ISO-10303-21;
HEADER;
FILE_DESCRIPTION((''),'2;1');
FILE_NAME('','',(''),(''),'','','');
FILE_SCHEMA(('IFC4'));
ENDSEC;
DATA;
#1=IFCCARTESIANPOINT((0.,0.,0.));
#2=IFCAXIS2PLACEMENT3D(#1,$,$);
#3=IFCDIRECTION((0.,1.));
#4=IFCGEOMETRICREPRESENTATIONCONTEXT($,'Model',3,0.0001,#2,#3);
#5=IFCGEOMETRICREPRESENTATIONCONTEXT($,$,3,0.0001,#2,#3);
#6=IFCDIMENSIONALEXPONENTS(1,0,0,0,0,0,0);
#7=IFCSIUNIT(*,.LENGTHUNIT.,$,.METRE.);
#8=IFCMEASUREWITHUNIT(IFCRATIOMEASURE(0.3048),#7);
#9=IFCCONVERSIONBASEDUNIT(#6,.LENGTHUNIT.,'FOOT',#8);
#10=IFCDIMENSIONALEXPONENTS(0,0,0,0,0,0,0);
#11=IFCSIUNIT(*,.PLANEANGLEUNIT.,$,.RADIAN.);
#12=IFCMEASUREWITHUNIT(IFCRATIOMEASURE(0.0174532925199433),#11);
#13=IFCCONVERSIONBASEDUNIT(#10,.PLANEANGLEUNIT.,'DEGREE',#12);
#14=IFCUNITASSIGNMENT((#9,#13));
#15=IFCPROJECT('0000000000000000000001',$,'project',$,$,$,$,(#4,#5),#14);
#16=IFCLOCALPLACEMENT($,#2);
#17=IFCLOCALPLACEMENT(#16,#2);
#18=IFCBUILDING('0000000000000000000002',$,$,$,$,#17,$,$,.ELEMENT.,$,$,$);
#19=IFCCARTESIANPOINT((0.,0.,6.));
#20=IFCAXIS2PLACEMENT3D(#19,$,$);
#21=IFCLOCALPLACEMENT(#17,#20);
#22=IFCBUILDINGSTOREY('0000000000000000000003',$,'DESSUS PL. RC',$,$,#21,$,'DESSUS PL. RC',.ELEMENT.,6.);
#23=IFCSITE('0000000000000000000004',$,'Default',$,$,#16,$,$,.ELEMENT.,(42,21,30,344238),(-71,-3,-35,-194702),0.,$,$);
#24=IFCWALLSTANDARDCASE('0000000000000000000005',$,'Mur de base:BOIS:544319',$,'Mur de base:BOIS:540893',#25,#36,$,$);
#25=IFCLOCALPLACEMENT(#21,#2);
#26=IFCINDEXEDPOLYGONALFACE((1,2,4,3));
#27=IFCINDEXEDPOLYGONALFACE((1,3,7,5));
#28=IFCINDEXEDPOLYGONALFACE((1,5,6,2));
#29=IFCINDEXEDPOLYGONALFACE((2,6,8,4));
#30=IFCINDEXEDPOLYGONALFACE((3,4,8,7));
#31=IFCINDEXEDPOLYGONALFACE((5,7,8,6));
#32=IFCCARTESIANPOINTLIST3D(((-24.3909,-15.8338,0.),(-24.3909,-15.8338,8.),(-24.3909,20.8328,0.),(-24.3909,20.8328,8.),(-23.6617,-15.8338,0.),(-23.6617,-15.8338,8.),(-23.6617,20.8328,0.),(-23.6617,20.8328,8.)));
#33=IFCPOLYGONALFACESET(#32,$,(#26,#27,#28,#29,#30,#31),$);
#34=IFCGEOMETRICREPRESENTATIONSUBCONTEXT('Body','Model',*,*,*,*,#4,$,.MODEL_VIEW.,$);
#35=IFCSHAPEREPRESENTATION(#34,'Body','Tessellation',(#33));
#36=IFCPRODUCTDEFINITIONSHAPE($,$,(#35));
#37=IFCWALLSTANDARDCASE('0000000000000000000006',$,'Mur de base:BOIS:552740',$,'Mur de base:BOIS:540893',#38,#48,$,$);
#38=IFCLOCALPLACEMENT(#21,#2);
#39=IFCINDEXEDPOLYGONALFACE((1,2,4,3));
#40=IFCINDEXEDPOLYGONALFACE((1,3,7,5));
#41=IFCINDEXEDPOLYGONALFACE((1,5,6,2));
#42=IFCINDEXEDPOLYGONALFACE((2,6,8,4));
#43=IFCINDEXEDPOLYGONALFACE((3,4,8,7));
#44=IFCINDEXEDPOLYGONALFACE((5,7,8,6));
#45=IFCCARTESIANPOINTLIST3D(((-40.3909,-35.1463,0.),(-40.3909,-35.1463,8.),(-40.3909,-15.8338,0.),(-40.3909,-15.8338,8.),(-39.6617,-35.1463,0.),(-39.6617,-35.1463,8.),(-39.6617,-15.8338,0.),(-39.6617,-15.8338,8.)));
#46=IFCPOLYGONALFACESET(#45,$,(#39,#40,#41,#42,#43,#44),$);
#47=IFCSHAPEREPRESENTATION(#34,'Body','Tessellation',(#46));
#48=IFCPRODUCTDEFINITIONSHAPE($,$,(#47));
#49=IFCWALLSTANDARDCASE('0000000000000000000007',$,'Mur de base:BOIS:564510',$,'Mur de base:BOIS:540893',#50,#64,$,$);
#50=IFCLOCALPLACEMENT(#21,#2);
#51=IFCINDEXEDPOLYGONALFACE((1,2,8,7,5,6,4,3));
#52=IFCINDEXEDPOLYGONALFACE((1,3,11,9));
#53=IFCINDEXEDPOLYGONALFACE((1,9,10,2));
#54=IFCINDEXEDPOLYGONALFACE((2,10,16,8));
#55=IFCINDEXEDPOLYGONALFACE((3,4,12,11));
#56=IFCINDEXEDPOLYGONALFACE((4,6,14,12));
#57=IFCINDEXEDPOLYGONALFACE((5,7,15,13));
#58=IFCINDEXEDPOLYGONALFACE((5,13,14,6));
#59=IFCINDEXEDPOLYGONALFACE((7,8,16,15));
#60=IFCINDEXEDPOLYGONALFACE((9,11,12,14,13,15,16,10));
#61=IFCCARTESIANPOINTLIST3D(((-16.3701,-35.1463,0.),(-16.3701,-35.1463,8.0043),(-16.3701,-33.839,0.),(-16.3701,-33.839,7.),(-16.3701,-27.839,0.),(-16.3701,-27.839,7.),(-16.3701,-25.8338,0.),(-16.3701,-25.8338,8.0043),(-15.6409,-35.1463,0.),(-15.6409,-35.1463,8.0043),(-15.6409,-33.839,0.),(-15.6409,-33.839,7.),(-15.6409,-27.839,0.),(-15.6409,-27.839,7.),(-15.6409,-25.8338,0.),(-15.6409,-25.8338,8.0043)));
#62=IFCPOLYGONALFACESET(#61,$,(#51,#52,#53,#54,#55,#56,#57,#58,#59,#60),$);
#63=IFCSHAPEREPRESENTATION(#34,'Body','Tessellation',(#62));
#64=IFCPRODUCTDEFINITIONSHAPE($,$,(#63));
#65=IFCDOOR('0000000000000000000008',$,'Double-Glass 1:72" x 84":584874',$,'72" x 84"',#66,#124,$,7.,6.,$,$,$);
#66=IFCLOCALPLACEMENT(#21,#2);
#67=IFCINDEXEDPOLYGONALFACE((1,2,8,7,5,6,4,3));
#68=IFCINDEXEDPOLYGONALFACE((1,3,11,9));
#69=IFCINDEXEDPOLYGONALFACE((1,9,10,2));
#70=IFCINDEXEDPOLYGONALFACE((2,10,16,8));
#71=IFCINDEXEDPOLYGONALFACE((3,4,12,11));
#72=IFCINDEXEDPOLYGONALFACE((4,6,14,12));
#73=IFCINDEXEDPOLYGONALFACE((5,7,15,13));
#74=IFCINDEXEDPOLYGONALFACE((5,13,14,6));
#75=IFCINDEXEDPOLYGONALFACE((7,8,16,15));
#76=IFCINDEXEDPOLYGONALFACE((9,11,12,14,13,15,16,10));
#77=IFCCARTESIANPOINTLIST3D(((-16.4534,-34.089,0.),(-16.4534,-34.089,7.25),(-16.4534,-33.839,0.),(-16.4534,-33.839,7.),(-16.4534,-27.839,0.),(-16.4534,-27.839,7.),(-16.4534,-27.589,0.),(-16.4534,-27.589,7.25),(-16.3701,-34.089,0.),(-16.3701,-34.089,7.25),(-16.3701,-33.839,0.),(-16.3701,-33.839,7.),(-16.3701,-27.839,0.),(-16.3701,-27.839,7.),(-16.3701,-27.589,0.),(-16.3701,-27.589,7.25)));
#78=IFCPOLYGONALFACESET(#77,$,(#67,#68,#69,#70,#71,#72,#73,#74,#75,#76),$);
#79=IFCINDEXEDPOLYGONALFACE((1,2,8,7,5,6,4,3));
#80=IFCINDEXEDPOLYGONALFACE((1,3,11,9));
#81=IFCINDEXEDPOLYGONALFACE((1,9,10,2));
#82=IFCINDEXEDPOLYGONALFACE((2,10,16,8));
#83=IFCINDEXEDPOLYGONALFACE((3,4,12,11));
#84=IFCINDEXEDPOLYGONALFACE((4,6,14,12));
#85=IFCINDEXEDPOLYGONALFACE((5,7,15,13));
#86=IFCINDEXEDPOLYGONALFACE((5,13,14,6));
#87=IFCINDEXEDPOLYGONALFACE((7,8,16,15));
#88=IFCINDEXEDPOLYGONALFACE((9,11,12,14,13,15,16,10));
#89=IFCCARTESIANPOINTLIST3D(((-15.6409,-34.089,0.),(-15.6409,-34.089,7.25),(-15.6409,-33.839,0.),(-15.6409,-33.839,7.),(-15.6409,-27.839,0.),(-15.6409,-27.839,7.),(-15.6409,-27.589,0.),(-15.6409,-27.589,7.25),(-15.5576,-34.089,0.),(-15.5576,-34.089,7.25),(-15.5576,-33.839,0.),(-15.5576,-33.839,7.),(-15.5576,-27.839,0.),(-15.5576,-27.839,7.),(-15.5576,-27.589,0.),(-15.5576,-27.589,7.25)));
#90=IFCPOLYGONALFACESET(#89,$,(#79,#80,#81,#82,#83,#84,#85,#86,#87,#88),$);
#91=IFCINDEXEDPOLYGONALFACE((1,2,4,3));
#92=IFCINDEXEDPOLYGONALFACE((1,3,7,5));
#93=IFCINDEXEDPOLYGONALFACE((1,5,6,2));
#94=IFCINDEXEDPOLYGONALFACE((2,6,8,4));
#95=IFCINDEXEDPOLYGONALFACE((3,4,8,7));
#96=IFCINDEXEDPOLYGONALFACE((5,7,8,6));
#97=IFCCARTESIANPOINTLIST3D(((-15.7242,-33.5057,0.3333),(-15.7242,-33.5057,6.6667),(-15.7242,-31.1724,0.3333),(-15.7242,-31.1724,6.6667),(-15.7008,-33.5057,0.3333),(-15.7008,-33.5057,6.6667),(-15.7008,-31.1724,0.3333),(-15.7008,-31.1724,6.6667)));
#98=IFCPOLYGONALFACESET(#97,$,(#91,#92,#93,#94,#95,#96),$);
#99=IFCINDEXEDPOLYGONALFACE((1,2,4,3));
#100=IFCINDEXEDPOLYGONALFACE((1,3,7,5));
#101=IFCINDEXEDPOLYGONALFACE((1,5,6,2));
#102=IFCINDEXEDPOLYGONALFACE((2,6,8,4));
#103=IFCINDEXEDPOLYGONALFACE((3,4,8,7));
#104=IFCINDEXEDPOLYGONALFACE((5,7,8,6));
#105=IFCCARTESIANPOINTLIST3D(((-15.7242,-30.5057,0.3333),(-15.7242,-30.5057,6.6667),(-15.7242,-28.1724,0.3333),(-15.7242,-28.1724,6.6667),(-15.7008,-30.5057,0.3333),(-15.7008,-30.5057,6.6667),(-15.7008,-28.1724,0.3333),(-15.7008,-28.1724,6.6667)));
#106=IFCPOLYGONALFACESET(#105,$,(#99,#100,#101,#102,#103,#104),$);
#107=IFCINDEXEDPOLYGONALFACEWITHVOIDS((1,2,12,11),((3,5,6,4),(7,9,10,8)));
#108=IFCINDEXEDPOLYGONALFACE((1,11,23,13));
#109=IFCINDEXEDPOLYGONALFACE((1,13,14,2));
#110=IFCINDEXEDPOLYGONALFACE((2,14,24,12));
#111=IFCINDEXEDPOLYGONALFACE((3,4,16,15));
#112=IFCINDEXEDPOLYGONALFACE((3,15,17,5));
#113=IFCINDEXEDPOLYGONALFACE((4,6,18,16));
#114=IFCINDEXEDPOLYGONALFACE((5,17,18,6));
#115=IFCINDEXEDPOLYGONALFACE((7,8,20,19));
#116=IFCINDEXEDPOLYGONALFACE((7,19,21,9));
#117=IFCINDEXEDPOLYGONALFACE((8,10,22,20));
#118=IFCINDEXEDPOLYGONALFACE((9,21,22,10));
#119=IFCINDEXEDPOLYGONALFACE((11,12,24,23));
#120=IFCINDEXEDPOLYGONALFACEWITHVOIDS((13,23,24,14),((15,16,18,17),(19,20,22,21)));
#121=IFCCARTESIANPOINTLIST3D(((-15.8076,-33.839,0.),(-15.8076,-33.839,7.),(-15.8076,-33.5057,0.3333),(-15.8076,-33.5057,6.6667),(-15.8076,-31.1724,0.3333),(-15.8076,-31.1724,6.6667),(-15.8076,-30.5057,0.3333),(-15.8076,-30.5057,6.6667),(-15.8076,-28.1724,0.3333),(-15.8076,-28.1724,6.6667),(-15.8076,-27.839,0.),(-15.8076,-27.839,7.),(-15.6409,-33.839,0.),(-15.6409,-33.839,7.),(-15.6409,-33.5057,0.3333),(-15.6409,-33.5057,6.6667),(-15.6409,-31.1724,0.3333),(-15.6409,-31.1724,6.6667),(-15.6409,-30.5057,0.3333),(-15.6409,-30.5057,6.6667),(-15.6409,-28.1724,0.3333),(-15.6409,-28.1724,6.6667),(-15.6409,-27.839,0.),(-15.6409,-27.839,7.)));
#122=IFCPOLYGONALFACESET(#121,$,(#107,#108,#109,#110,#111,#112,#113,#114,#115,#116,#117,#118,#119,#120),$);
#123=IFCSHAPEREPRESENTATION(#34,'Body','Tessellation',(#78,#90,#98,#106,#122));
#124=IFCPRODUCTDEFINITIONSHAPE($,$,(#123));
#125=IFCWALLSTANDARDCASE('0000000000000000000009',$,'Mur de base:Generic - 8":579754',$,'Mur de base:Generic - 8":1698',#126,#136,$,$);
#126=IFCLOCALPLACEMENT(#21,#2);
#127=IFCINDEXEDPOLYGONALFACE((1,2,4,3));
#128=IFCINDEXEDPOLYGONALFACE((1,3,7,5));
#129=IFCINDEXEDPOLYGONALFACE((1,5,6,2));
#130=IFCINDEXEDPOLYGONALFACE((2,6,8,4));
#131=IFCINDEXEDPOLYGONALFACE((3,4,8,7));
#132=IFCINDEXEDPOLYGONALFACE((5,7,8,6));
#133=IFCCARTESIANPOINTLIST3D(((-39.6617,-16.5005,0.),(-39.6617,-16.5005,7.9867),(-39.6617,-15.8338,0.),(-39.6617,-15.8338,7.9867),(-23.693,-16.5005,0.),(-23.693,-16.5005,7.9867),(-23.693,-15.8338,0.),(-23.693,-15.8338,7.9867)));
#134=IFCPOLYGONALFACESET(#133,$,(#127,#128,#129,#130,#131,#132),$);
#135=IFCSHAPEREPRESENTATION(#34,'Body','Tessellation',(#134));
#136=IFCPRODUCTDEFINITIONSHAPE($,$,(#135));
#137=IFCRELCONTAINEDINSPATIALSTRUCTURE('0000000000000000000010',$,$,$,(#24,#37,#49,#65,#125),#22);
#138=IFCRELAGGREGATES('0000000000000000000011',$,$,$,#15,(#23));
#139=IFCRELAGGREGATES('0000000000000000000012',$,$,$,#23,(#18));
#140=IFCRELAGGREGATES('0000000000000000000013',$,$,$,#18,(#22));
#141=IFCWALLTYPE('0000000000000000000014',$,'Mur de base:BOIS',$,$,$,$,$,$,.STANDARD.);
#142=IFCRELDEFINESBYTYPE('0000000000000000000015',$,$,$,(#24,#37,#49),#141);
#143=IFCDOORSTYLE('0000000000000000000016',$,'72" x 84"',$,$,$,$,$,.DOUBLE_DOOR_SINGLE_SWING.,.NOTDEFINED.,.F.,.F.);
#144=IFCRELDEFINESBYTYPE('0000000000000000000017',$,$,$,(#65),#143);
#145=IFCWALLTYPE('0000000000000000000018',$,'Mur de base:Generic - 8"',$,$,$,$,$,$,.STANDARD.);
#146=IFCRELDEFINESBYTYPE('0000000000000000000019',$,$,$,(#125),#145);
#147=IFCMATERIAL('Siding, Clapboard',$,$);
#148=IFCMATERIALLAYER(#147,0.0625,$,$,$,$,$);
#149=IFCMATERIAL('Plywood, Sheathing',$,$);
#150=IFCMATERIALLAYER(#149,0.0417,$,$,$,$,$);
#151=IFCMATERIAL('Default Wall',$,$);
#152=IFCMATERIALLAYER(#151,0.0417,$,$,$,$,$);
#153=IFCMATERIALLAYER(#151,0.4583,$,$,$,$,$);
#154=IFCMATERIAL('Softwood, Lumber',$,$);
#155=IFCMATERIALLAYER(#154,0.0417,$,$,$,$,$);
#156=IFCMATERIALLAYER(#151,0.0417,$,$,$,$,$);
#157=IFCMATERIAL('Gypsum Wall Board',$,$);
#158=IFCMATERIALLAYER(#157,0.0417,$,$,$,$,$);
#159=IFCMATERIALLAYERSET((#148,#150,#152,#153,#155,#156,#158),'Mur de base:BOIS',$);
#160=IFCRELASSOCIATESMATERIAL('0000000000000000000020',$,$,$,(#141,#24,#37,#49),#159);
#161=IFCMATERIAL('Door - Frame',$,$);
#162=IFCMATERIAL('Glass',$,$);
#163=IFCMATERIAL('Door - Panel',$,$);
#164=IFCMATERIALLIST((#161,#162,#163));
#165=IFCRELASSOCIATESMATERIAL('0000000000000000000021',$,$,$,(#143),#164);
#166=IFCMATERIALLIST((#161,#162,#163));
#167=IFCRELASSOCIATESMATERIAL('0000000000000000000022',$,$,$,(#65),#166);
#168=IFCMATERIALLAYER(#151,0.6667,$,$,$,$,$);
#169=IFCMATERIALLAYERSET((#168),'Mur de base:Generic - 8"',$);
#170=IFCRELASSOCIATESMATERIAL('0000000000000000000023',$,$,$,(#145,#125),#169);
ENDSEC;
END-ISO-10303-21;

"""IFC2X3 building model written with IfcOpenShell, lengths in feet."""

from ifc_helpers import new_model, entity, si_unit, converted_unit, direction, frame, frame_2d, origin, origin_2d_with_axis, place, context, subcontext, project, spatial, polyline, rectangle, outline, extrude, source, transform, mapped, material, material_list, layer, layer_set, layer_usage, type_object, type_shapes, element, fill, save


model = new_model("IFC2X3")

# Units and contexts
model_context = context("Model", 3, precision=0.0001, world=origin(), true_north=direction((0.0, 1.0)))
context_of_model = context(None, 3, precision=0.0001, world=origin(), true_north=direction((0.0, 1.0)))
body_context = subcontext(model_context, "Body", "Model", "MODEL_VIEW")
ifc_project = project(units=[converted_unit("LENGTHUNIT", "FOOT", entity("IfcRatioMeasure", 0.3048), si_unit("LENGTHUNIT", "METRE"), dimensions=[1, 0, 0, 0, 0, 0, 0]), converted_unit("PLANEANGLEUNIT", "DEGREE", entity("IfcRatioMeasure", 0.0174532925199433), si_unit("PLANEANGLEUNIT", "RADIAN"), dimensions=[0, 0, 0, 0, 0, 0, 0])], contexts=[model_context, context_of_model])

# Site, building, storey
site_placement = place(None, origin())
site = spatial("IfcSite", under=ifc_project, at=site_placement, Name="Default", CompositionType="ELEMENT", RefLatitude=(42, 21, 30, 344238), RefLongitude=(-71, -3, -35, -194702), RefElevation=0.0)
building_placement = place(site_placement, origin())
building = spatial("IfcBuilding", under=site, at=building_placement, CompositionType="ELEMENT")
storey_placement = place(building_placement, frame((0.0, 0.0, 6.0)))
storey = spatial("IfcBuildingStorey", under=building, at=storey_placement, Name="DESSUS PL. RC", LongName="DESSUS PL. RC", CompositionType="ELEMENT", Elevation=6.0)

# Wall
ifc_material_1 = material(Name="Siding, Clapboard")
ifc_layer_1 = layer(ifc_material_1, 0.0625)
ifc_material_2 = material(Name="Plywood, Sheathing")
ifc_layer_2 = layer(ifc_material_2, 0.0417)
ifc_material_3 = material(Name="Default Wall")
ifc_layer_3 = layer(ifc_material_3, 0.0417)
ifc_layer_4 = layer(ifc_material_3, 0.4583)
ifc_material_4 = material(Name="Softwood, Lumber")
ifc_layer_5 = layer(ifc_material_4, 0.0417)
ifc_layer_6 = layer(ifc_material_3, 0.0417)
ifc_material_5 = material(Name="Gypsum Wall Board")
ifc_layer_7 = layer(ifc_material_5, 0.0417)
ifc_layer_set_1 = layer_set([ifc_layer_1, ifc_layer_2, ifc_layer_3, ifc_layer_4, ifc_layer_5, ifc_layer_6, ifc_layer_7], Name="Mur de base:BOIS")
ifc_layer_usage_1 = layer_usage(ifc_layer_set_1, "AXIS2", "NEGATIVE", 0.3646)
wall_type_1 = type_object("IfcWallType", Name="Mur de base:BOIS", PredefinedType="STANDARD", material=ifc_layer_set_1)
wall_1_placement = place(storey_placement, frame((-24.0263, -15.8338, 0.0), z_axis=(0.0, 0.0, 1.0), x_axis=(0.0, 1.0, 0.0)))
element("IfcWallStandardCase", 1, at=wall_1_placement, inside=storey, type_object=wall_type_1, material=ifc_layer_usage_1, Name="Mur de base:BOIS:544319", ObjectType="Mur de base:BOIS:540893", context=body_context, shape_type="SweptSolid", body=[
    extrude(rectangle(XDim=36.6667, YDim=0.7292, at=frame_2d((18.3333, 0.0), x_axis=(-1.0, 0.0))), origin(), (0.0, 0.0, 1.0), 8.0),
])

# Shared definitions
ifc_material_6 = material(Name="Glass")

# Wall
ifc_layer_usage_2 = layer_usage(ifc_layer_set_1, "AXIS2", "NEGATIVE", 0.3646)
wall_2_placement = place(storey_placement, frame((-40.0263, -35.1463, 0.0), z_axis=(0.0, 0.0, 1.0), x_axis=(0.0, 1.0, 0.0)))
element("IfcWallStandardCase", 2, at=wall_2_placement, inside=storey, type_object=wall_type_1, material=ifc_layer_usage_2, Name="Mur de base:BOIS:552740", ObjectType="Mur de base:BOIS:540893", context=body_context, shape_type="SweptSolid", body=[
    extrude(rectangle(XDim=19.3125, YDim=0.7292, at=frame_2d((9.6562, 0.0), x_axis=(-1.0, 0.0))), origin(), (0.0, 0.0, 1.0), 8.0),
])

# Wall, opening, door
ifc_layer_usage_3 = layer_usage(ifc_layer_set_1, "AXIS2", "NEGATIVE", 0.3646)
wall_3_placement = place(storey_placement, frame((-16.0055, -35.1463, 0.0), z_axis=(0.0, 0.0, 1.0), x_axis=(0.0, 1.0, 0.0)))
wall_3 = element("IfcWallStandardCase", 3, at=wall_3_placement, inside=storey, type_object=wall_type_1, material=ifc_layer_usage_3, Name="Mur de base:BOIS:564510", ObjectType="Mur de base:BOIS:540893", context=body_context, shape_type="SweptSolid", body=[
    extrude(rectangle(XDim=9.3125, YDim=0.7292, at=frame_2d((4.6562, 0.0), x_axis=(-1.0, 0.0))), origin(), (0.0, 0.0, 1.0), 8.0043),
])
opening_1_placement = place(wall_3_placement, frame((7.3073, 0.3646, 0.0)))
opening_1 = element("IfcOpeningElement", 4, at=opening_1_placement, cuts=wall_3, ObjectType="Opening", context=body_context, shape_type="SweptSolid", body=[
    extrude(rectangle(XDim=6.0, YDim=7.0, at=frame_2d((3.5, 3.0), x_axis=(0.0, 1.0))), frame((0.0, 0.0, 0.0), z_axis=(0.0, -1.0, 0.0), x_axis=(0.0, 0.0, 1.0)), (0.0, 0.0, 1.0), 0.7292),
])
ifc_material_7 = material(Name="Door - Frame")
ifc_material_8 = material(Name="Door - Panel")
ifc_material_list_1 = material_list([ifc_material_7, ifc_material_6, ifc_material_8])
ifc_material_list_2 = material_list([ifc_material_7, ifc_material_6, ifc_material_8])
door_style_1 = type_object("IfcDoorStyle", Name="72\" x 84\"", ConstructionType="NOTDEFINED", OperationType="DOUBLE_DOOR_SINGLE_SWING", ParameterTakesPrecedence=False, Sizeable=False, material=ifc_material_list_2)
shared_shape_1 = source(origin(), body_context, "Body", "SweptSolid", [
    extrude(outline(polyline([(-3.25, -3.5625), (-3.0, -3.5625), (-3.0, 3.4375), (3.0, 3.4375), (3.0, -3.5625), (3.25, -3.5625), (3.25, 3.6875), (-3.25, 3.6875), (-3.25, -3.5625)])), frame((3.0, -0.0833, 3.5625), z_axis=(0.0, 1.0, 0.0), x_axis=(-1.0, 0.0, 0.0)), (0.0, 0.0, 1.0), 0.0833),
    extrude(outline(polyline([(-3.0, -3.4375), (-3.0, 3.5625), (-3.25, 3.5625), (-3.25, -3.6875), (3.25, -3.6875), (3.25, 3.5625), (3.0, 3.5625), (3.0, -3.4375), (-3.0, -3.4375)])), frame((3.0, 0.7292, 3.5625), z_axis=(0.0, -1.0, 0.0), x_axis=(-1.0, 0.0, 0.0)), (0.0, 0.0, -1.0), 0.0833),
    extrude(rectangle(XDim=0.0234, YDim=2.3333, at=frame_2d((0.0, 0.0), x_axis=(1.0, 0.0))), frame((4.5, 0.6576, 0.3333), z_axis=(0.0, 0.0, 1.0), x_axis=(0.0, 1.0, 0.0)), (0.0, 0.0, 1.0), 6.3333),
    extrude(rectangle(XDim=0.0234, YDim=2.3333, at=origin_2d_with_axis()), frame((1.5, 0.6576, 0.3333), z_axis=(0.0, 0.0, 1.0), x_axis=(0.0, 1.0, 0.0)), (0.0, 0.0, 1.0), 6.3333),
    extrude(outline(polyline([(-3.5, -3.0), (3.5, -3.0), (3.5, 3.0), (-3.5, 3.0), (-3.5, -3.0)]), holes=[polyline([(-3.1667, 0.3333), (-3.1667, 2.6667), (3.1667, 2.6667), (3.1667, 0.3333), (-3.1667, 0.3333)]), polyline([(-3.1667, -2.6667), (-3.1667, -0.3333), (3.1667, -0.3333), (3.1667, -2.6667), (-3.1667, -2.6667)])]), frame((3.0, 0.5625, 3.5), z_axis=(0.0, 1.0, 0.0), x_axis=(0.0, 0.0, -1.0)), (0.0, 0.0, 1.0), 0.1667),
])
type_shapes(door_style_1, [shared_shape_1])
door_1_placement = place(opening_1_placement, frame((0.0, 0.0, 0.0), z_axis=(0.0, 0.0, 1.0), x_axis=(-1.0, 0.0, 0.0)))
door_1 = element("IfcDoor", 5, at=door_1_placement, inside=storey, type_object=door_style_1, material=ifc_material_list_1, Name="Double-Glass 1:72\" x 84\":584874", ObjectType="72\" x 84\"", OverallHeight=7.0, OverallWidth=6.0, context=body_context, shape_type="MappedRepresentation", body=[
    mapped(shared_shape_1, transform((0.0, 0.0, 0.0), scale=1.0)),
])
fill(opening_1, door_1)

# Wall
ifc_layer_8 = layer(ifc_material_3, 0.6667)
ifc_layer_set_2 = layer_set([ifc_layer_8], Name="Mur de base:Generic - 8\"")
ifc_layer_usage_4 = layer_usage(ifc_layer_set_2, "AXIS2", "NEGATIVE", 0.3333)
wall_type_2 = type_object("IfcWallType", Name="Mur de base:Generic - 8\"", PredefinedType="STANDARD", material=ifc_layer_set_2)
wall_4_placement = place(storey_placement, frame((-23.693, -16.1672, 0.0), z_axis=(0.0, 0.0, 1.0), x_axis=(-1.0, 0.0, 0.0)))
element("IfcWallStandardCase", 6, at=wall_4_placement, inside=storey, type_object=wall_type_2, material=ifc_layer_usage_4, Name="Mur de base:Generic - 8\":579754", ObjectType="Mur de base:Generic - 8\":1698", context=body_context, shape_type="SweptSolid", body=[
    extrude(rectangle(XDim=15.9688, YDim=0.6667, at=frame_2d((7.9844, 0.0), x_axis=(-1.0, 0.0))), origin(), (0.0, 0.0, 1.0), 7.9867),
])

save(model, "model.ifc")
